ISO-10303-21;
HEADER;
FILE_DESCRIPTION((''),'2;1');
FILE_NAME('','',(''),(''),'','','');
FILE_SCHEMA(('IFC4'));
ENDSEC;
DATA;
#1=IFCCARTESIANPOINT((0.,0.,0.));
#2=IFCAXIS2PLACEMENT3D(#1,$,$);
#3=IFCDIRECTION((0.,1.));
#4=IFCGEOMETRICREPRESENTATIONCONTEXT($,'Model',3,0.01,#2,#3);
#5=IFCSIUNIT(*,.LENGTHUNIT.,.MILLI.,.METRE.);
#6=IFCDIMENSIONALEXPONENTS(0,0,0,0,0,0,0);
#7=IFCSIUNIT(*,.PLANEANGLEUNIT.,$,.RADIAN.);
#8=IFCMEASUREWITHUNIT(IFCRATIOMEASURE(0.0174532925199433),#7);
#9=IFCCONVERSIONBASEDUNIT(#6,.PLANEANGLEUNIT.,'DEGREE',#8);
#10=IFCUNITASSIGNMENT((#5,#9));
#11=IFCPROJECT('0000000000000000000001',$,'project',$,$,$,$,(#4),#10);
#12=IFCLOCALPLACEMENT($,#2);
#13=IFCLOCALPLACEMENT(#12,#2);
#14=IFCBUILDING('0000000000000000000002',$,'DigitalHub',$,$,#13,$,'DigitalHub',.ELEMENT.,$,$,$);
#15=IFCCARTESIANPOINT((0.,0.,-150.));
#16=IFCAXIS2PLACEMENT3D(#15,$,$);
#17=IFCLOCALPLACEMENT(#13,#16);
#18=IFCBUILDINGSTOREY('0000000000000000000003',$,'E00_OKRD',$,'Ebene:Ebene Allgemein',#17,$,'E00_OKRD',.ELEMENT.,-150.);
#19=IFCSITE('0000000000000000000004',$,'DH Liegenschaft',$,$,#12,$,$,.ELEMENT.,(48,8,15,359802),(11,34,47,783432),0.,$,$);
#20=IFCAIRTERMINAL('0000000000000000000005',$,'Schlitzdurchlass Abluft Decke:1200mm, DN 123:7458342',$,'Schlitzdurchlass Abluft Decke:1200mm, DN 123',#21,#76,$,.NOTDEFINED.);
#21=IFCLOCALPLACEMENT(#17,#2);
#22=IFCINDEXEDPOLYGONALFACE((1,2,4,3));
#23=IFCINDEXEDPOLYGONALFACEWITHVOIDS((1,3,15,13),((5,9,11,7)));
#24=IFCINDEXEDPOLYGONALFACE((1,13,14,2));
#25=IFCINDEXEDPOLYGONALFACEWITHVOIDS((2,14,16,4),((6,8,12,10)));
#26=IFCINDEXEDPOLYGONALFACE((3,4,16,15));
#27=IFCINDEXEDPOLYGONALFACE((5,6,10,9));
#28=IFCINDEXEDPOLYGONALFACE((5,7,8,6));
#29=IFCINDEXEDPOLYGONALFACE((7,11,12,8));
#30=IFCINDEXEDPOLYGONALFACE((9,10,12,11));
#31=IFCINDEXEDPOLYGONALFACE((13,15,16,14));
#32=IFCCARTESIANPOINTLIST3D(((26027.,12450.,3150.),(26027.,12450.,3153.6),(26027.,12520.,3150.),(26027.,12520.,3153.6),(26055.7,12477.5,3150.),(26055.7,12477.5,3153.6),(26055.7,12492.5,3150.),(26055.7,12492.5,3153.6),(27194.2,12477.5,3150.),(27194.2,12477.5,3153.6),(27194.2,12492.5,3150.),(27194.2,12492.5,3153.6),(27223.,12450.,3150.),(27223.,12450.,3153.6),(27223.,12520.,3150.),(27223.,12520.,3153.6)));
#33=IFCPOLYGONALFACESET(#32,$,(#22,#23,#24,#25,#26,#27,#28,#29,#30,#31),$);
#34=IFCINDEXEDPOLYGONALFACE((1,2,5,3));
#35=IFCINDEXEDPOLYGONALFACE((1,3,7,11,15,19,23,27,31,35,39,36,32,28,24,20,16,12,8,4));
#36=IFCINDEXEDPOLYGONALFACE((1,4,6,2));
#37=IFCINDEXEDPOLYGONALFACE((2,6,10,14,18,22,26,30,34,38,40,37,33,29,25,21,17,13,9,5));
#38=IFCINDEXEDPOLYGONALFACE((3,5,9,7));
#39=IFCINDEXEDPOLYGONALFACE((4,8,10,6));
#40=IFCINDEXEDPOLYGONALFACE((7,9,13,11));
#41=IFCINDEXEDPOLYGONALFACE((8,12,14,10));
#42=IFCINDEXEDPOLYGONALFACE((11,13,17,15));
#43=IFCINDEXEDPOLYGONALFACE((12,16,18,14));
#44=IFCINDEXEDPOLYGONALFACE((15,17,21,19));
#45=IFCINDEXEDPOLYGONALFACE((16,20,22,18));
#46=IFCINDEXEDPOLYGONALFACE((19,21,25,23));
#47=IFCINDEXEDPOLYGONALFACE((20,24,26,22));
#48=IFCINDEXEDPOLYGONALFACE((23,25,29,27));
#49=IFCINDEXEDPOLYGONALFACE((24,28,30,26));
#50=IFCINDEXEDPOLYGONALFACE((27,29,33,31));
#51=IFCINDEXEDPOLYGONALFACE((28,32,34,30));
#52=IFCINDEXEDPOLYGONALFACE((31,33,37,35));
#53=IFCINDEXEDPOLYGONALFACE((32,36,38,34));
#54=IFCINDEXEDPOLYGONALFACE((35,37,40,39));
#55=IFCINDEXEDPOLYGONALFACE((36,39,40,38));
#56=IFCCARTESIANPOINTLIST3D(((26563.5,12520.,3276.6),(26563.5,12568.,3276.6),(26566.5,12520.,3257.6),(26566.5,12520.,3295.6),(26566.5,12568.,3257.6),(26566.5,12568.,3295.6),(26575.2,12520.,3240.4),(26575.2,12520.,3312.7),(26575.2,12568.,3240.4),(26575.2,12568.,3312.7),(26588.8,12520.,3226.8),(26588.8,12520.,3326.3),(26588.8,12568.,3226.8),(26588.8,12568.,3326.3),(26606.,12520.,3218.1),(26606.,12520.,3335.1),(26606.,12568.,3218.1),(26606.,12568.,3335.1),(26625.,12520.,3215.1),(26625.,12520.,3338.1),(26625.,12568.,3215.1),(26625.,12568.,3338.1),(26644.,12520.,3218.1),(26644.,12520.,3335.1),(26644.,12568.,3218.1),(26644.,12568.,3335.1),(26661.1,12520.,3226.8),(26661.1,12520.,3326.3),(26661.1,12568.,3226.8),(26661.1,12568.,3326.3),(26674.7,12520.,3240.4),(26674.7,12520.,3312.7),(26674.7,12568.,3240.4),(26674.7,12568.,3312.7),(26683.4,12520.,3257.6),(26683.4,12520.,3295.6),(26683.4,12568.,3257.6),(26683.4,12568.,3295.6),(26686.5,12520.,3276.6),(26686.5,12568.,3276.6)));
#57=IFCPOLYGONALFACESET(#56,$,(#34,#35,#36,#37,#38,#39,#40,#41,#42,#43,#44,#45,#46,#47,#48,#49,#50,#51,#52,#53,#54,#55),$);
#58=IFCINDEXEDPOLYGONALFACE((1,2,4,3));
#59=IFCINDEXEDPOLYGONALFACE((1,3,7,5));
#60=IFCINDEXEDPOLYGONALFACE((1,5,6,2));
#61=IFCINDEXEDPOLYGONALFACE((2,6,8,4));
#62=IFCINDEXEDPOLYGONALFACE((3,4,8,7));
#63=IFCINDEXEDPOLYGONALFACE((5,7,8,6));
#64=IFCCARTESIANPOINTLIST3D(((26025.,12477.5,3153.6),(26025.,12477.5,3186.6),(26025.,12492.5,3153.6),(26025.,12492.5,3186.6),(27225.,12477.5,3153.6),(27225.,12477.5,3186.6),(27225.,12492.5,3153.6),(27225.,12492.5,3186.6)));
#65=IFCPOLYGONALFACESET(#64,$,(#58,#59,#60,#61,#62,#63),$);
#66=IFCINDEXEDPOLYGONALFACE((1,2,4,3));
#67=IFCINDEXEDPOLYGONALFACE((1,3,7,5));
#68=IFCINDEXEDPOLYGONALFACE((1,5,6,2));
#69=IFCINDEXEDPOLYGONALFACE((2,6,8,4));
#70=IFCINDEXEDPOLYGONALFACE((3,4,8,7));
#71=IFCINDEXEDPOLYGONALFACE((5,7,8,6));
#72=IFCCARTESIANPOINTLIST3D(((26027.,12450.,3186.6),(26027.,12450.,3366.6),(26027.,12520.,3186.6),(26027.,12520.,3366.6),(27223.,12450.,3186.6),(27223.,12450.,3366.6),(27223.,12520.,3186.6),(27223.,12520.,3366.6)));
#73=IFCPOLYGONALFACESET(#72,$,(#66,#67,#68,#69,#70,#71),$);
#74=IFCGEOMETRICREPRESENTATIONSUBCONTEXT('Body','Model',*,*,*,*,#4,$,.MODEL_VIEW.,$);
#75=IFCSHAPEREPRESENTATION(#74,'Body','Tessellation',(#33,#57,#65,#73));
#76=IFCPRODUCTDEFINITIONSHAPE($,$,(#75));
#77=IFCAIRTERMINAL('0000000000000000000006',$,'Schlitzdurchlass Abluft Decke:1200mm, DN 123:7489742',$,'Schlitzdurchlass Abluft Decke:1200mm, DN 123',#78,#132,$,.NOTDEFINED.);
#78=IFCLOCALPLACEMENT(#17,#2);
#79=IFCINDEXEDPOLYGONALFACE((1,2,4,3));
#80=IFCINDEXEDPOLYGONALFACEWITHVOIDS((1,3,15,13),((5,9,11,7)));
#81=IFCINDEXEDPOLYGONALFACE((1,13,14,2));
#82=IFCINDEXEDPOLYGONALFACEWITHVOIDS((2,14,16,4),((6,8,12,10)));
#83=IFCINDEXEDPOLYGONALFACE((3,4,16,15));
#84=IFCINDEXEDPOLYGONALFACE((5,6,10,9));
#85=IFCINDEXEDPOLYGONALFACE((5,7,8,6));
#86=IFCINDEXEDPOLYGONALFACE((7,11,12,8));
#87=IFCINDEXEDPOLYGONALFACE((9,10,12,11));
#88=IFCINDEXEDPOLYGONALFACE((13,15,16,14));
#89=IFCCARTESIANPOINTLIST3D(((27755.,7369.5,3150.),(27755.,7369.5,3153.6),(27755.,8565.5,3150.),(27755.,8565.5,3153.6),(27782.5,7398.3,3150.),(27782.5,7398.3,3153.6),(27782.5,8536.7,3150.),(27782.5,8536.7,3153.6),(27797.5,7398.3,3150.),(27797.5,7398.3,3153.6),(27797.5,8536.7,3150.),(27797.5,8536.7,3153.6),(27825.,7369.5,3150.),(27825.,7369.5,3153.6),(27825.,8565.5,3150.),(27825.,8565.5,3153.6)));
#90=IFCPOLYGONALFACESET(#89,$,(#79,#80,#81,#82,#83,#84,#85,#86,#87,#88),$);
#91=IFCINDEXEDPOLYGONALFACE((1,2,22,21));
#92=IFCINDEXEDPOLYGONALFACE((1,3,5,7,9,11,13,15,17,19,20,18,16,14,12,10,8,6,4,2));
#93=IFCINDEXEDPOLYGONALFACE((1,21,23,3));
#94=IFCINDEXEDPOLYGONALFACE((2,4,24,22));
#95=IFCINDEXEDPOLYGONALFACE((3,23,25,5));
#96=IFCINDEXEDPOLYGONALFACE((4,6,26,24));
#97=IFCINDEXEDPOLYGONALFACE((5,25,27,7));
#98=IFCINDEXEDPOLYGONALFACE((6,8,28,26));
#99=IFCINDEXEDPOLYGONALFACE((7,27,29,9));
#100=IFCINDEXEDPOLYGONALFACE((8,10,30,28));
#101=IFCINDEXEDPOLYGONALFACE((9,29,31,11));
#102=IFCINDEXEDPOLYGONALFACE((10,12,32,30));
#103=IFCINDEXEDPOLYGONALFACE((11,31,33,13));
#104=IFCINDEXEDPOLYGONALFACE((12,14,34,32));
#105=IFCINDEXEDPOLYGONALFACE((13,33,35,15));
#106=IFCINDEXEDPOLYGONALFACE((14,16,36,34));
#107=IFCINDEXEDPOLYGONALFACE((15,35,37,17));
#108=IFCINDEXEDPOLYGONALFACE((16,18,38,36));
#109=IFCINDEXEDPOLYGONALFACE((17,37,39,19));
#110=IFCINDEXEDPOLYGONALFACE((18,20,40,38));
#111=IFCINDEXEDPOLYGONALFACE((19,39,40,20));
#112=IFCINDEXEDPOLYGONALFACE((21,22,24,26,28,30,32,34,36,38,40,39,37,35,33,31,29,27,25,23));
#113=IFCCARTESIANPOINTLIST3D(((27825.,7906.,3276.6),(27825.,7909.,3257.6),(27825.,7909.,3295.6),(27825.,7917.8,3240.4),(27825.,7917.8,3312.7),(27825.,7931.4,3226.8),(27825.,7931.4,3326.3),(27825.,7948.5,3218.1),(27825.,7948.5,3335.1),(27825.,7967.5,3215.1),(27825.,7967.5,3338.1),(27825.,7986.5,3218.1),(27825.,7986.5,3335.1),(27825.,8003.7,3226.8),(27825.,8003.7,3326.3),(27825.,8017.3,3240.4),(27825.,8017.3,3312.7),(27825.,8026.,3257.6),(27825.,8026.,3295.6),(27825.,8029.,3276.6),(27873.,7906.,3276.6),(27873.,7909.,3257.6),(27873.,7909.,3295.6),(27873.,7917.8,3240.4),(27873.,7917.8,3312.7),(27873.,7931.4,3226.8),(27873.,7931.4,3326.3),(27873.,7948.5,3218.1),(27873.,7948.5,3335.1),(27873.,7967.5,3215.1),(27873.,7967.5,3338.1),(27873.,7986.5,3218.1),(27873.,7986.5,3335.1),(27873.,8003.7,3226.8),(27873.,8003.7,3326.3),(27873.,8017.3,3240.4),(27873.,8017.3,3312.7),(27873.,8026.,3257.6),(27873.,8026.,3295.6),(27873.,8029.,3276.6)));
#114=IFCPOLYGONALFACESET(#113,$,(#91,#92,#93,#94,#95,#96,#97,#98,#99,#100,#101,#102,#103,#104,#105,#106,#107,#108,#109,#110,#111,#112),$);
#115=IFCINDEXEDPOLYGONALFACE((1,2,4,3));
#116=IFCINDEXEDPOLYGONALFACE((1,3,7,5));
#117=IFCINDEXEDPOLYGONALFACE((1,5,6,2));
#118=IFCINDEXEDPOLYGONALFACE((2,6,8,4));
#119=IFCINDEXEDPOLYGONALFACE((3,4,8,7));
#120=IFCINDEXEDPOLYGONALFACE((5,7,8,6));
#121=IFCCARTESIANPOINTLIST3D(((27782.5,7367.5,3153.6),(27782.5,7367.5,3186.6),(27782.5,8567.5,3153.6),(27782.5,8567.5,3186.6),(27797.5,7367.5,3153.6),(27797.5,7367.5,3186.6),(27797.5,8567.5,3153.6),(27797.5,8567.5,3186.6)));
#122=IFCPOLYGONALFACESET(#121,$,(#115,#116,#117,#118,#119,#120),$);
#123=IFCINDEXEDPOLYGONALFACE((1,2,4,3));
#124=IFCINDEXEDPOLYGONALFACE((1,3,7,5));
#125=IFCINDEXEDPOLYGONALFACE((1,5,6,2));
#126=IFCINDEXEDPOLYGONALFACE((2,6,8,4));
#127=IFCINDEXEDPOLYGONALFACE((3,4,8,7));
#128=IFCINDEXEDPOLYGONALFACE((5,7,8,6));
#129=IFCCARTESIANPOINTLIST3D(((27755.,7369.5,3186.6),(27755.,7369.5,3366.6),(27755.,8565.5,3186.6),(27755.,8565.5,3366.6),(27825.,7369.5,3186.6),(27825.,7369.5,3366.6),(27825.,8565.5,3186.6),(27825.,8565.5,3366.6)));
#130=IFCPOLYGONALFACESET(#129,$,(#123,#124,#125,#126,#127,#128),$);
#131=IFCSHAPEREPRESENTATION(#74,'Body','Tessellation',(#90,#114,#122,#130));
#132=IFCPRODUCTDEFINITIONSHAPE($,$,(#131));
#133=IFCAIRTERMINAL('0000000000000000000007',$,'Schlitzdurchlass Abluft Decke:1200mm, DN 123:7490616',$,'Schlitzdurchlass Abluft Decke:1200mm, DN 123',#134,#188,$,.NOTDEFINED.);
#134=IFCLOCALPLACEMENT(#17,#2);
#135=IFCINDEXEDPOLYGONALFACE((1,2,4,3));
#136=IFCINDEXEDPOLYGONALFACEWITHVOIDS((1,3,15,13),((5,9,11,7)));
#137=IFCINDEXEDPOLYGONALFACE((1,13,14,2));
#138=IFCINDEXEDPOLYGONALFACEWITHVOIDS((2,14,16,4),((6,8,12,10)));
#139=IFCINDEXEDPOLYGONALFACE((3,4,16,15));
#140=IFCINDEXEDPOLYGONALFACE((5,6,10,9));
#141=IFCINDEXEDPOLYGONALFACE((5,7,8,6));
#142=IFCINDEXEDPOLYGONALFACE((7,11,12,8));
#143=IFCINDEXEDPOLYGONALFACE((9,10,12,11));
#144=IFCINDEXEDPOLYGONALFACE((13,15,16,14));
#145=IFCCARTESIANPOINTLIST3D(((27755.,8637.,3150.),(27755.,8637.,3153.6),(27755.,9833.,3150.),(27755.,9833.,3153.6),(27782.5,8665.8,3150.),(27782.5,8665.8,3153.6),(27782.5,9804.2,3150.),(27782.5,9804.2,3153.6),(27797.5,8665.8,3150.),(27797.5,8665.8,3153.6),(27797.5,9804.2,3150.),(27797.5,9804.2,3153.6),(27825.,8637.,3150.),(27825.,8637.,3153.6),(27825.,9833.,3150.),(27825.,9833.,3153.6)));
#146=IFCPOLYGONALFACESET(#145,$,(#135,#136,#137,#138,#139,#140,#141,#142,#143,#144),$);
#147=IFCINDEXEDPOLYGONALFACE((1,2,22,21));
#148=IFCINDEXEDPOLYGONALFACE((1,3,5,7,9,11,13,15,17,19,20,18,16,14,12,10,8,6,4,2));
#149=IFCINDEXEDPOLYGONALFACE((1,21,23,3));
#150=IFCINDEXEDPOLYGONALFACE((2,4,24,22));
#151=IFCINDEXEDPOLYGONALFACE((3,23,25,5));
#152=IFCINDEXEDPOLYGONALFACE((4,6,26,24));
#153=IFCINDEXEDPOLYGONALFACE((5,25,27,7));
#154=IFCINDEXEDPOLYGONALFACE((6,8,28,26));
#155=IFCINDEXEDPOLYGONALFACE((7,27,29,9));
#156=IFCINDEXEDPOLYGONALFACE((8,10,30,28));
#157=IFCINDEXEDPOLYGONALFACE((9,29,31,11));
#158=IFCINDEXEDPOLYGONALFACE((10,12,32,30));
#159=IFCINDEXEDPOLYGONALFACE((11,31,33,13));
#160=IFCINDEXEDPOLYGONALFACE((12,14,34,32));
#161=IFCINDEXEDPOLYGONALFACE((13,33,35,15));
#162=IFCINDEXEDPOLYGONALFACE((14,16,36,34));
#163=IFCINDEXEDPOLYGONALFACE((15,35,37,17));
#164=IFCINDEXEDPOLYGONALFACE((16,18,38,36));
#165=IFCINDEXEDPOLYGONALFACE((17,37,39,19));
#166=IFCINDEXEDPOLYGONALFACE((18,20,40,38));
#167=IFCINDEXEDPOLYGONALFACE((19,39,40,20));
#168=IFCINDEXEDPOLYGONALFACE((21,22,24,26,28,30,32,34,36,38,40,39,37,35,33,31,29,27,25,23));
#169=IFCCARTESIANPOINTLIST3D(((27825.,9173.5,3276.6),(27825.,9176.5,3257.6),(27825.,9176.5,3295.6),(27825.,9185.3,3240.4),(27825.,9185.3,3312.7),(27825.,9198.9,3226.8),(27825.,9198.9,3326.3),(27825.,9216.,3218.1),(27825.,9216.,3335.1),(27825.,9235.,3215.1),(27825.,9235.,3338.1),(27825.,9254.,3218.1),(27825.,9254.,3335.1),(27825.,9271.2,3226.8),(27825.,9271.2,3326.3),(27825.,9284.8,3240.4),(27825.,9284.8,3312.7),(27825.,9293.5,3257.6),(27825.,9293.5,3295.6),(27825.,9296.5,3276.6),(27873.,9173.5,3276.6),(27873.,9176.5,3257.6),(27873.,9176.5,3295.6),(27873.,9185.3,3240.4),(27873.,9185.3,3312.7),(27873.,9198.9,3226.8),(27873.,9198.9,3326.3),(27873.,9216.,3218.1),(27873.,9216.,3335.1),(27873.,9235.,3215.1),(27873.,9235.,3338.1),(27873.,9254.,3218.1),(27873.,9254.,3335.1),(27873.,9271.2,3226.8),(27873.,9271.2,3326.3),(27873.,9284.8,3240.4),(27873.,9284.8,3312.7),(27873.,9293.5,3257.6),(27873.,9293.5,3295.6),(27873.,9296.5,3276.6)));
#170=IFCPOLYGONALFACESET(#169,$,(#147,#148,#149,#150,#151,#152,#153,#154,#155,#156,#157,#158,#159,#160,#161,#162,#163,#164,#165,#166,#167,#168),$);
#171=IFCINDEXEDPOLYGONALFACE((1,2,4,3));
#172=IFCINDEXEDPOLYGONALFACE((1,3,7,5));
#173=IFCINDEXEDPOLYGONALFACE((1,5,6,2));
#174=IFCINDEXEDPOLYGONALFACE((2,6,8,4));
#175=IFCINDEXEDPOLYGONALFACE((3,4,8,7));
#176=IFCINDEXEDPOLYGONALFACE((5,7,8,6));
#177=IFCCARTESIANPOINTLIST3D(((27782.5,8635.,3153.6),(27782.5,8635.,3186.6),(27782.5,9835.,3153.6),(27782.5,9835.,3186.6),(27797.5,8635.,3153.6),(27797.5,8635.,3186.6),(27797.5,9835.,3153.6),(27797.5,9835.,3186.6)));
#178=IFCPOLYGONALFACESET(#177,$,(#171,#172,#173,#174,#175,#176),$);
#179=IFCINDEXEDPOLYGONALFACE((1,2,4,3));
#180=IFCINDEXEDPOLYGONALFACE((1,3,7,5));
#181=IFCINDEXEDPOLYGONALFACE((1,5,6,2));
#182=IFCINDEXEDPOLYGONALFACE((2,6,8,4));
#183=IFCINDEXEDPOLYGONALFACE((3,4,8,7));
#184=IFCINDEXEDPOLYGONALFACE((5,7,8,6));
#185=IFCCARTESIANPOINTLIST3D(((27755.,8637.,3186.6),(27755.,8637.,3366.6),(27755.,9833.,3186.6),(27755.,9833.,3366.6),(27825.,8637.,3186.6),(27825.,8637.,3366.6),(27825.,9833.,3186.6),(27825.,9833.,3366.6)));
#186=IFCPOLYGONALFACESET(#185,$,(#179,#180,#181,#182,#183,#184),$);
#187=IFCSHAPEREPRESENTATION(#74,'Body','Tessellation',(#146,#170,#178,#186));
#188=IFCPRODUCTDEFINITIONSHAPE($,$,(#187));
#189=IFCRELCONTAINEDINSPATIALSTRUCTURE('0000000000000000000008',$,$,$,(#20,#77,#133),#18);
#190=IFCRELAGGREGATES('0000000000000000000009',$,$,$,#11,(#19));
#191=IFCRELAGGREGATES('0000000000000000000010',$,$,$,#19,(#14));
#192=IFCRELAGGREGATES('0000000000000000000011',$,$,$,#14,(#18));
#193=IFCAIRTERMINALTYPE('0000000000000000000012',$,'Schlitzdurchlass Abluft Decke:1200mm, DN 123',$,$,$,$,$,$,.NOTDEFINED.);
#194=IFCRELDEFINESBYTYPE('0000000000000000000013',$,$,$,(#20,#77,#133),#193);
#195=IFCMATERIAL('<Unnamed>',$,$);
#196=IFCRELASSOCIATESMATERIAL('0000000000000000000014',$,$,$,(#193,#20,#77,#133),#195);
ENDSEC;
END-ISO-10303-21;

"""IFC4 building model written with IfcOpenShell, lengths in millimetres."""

from ifc_helpers import new_model, entity, si_unit, converted_unit, direction, frame, origin, place, context, subcontext, project, spatial, indexed_curve, outline, extrude, source, transform, mapped, material, type_object, type_shapes, element, save


model = new_model("IFC4")

# Units and contexts
model_context = context("Model", 3, precision=0.01, world=origin(), true_north=direction((0.0, 1.0)))
body_context = subcontext(model_context, "Body", "Model", "MODEL_VIEW")
ifc_project = project(units=[si_unit("LENGTHUNIT", "METRE", prefix="MILLI"), converted_unit("PLANEANGLEUNIT", "DEGREE", entity("IfcRatioMeasure", 0.0174532925199433), si_unit("PLANEANGLEUNIT", "RADIAN"), dimensions=[0, 0, 0, 0, 0, 0, 0])], contexts=[model_context])

# Site, building, storey
site_placement = place(None, origin())
site = spatial("IfcSite", under=ifc_project, at=site_placement, Name="DH Liegenschaft", CompositionType="ELEMENT", RefLatitude=(48, 8, 15, 359802), RefLongitude=(11, 34, 47, 783432), RefElevation=0.0)
building_placement = place(site_placement, origin())
building = spatial("IfcBuilding", under=site, at=building_placement, Name="DigitalHub", LongName="DigitalHub", CompositionType="ELEMENT")
storey_placement = place(building_placement, frame((0.0, 0.0, -150.0)))
storey = spatial("IfcBuildingStorey", under=building, at=storey_placement, Name="E00_OKRD", ObjectType="Ebene:Ebene Allgemein", LongName="E00_OKRD", CompositionType="ELEMENT", Elevation=-150.0)

# Shared definitions
ifc_material_1 = material(Name="<Unnamed>")

# Air terminals
air_terminal_type_1 = type_object("IfcAirTerminalType", Name="Schlitzdurchlass Abluft Decke:1200mm, DN 123", PredefinedType="NOTDEFINED", material=ifc_material_1)
shared_shape_1 = source(origin(), body_context, "Body", "SweptSolid", [
    extrude(outline(indexed_curve([(-598.0, -35.0), (598.0, -35.0), (598.0, 35.0), (-598.0, 35.0), (-598.0, -35.0)], self_intersect=False), holes=[indexed_curve([(-569.2, -7.5), (-569.2, 7.5), (569.2, 7.5), (569.2, -7.5), (-569.2, -7.5)], self_intersect=False)]), frame((0.0, 0.0, 0.0), z_axis=(0.0, 0.0, 1.0), x_axis=(-1.0, 0.0, 0.0)), (0.0, 0.0, 1.0), 3.6),
    extrude(outline(indexed_curve([(61.5, 0.0), (58.5, 19.0), (49.8, 36.1), (36.1, 49.8), (19.0, 58.5), (0.0, 61.5), (-19.0, 58.5), (-36.1, 49.8), (-49.8, 36.1), (-58.5, 19.0), (-61.5, 0.0), (-58.5, -19.0), (-49.8, -36.1), (-36.1, -49.8), (-19.0, -58.5), (0.0, -61.5), (19.0, -58.5), (36.1, -49.8), (49.8, -36.1), (58.5, -19.0), (61.5, 0.0)], self_intersect=False)), frame((0.0, 35.0, 126.6), z_axis=(0.0, 1.0, 0.0), x_axis=(-1.0, 0.0, 0.0)), (0.0, 0.0, 1.0), 48.0),
    extrude(outline(indexed_curve([(-600.0, -7.5), (600.0, -7.5), (600.0, 7.5), (-600.0, 7.5), (-600.0, -7.5)], self_intersect=False)), frame((0.0, 0.0, 3.6), z_axis=(0.0, 0.0, 1.0), x_axis=(-1.0, 0.0, 0.0)), (0.0, 0.0, 1.0), 33.0),
    extrude(outline(indexed_curve([(-598.0, -35.0), (598.0, -35.0), (598.0, 35.0), (-598.0, 35.0), (-598.0, -35.0)], self_intersect=False)), frame((0.0, 0.0, 36.6), z_axis=(0.0, 0.0, 1.0), x_axis=(-1.0, 0.0, 0.0)), (0.0, 0.0, 1.0), 180.0),
])
type_shapes(air_terminal_type_1, [shared_shape_1])
air_terminal_1_placement = place(storey_placement, frame((26625.0, 12485.0, 3150.0)))
element("IfcAirTerminal", 1, at=air_terminal_1_placement, inside=storey, type_object=air_terminal_type_1, material=ifc_material_1, Name="Schlitzdurchlass Abluft Decke:1200mm, DN 123:7458342", ObjectType="Schlitzdurchlass Abluft Decke:1200mm, DN 123", PredefinedType="NOTDEFINED", context=body_context, shape_type="MappedRepresentation", body=[
    mapped(shared_shape_1, transform((0.0, 0.0, 0.0), scale=1.0)),
])
for number, where, z_axis, x_axis, name in (
    (2, (27790.0, 7967.5, 3150.0), (0.0, 0.0, 1.0), (0.0, -1.0, 0.0), "Schlitzdurchlass Abluft Decke:1200mm, DN 123:7489742"),
    (3, (27790.0, 9235.0, 3150.0), (0.0, 0.0, 1.0), (0.0, -1.0, 0.0), "Schlitzdurchlass Abluft Decke:1200mm, DN 123:7490616"),
):
    element("IfcAirTerminal", number, at=place(storey_placement, frame(where, z_axis=z_axis, x_axis=x_axis)), inside=storey, type_object=air_terminal_type_1, material=ifc_material_1, Name=name, ObjectType="Schlitzdurchlass Abluft Decke:1200mm, DN 123", PredefinedType="NOTDEFINED", context=body_context, shape_type="MappedRepresentation", body=[
        mapped(shared_shape_1, transform((0.0, 0.0, 0.0), scale=1.0)),
    ])

save(model, "model.ifc")
